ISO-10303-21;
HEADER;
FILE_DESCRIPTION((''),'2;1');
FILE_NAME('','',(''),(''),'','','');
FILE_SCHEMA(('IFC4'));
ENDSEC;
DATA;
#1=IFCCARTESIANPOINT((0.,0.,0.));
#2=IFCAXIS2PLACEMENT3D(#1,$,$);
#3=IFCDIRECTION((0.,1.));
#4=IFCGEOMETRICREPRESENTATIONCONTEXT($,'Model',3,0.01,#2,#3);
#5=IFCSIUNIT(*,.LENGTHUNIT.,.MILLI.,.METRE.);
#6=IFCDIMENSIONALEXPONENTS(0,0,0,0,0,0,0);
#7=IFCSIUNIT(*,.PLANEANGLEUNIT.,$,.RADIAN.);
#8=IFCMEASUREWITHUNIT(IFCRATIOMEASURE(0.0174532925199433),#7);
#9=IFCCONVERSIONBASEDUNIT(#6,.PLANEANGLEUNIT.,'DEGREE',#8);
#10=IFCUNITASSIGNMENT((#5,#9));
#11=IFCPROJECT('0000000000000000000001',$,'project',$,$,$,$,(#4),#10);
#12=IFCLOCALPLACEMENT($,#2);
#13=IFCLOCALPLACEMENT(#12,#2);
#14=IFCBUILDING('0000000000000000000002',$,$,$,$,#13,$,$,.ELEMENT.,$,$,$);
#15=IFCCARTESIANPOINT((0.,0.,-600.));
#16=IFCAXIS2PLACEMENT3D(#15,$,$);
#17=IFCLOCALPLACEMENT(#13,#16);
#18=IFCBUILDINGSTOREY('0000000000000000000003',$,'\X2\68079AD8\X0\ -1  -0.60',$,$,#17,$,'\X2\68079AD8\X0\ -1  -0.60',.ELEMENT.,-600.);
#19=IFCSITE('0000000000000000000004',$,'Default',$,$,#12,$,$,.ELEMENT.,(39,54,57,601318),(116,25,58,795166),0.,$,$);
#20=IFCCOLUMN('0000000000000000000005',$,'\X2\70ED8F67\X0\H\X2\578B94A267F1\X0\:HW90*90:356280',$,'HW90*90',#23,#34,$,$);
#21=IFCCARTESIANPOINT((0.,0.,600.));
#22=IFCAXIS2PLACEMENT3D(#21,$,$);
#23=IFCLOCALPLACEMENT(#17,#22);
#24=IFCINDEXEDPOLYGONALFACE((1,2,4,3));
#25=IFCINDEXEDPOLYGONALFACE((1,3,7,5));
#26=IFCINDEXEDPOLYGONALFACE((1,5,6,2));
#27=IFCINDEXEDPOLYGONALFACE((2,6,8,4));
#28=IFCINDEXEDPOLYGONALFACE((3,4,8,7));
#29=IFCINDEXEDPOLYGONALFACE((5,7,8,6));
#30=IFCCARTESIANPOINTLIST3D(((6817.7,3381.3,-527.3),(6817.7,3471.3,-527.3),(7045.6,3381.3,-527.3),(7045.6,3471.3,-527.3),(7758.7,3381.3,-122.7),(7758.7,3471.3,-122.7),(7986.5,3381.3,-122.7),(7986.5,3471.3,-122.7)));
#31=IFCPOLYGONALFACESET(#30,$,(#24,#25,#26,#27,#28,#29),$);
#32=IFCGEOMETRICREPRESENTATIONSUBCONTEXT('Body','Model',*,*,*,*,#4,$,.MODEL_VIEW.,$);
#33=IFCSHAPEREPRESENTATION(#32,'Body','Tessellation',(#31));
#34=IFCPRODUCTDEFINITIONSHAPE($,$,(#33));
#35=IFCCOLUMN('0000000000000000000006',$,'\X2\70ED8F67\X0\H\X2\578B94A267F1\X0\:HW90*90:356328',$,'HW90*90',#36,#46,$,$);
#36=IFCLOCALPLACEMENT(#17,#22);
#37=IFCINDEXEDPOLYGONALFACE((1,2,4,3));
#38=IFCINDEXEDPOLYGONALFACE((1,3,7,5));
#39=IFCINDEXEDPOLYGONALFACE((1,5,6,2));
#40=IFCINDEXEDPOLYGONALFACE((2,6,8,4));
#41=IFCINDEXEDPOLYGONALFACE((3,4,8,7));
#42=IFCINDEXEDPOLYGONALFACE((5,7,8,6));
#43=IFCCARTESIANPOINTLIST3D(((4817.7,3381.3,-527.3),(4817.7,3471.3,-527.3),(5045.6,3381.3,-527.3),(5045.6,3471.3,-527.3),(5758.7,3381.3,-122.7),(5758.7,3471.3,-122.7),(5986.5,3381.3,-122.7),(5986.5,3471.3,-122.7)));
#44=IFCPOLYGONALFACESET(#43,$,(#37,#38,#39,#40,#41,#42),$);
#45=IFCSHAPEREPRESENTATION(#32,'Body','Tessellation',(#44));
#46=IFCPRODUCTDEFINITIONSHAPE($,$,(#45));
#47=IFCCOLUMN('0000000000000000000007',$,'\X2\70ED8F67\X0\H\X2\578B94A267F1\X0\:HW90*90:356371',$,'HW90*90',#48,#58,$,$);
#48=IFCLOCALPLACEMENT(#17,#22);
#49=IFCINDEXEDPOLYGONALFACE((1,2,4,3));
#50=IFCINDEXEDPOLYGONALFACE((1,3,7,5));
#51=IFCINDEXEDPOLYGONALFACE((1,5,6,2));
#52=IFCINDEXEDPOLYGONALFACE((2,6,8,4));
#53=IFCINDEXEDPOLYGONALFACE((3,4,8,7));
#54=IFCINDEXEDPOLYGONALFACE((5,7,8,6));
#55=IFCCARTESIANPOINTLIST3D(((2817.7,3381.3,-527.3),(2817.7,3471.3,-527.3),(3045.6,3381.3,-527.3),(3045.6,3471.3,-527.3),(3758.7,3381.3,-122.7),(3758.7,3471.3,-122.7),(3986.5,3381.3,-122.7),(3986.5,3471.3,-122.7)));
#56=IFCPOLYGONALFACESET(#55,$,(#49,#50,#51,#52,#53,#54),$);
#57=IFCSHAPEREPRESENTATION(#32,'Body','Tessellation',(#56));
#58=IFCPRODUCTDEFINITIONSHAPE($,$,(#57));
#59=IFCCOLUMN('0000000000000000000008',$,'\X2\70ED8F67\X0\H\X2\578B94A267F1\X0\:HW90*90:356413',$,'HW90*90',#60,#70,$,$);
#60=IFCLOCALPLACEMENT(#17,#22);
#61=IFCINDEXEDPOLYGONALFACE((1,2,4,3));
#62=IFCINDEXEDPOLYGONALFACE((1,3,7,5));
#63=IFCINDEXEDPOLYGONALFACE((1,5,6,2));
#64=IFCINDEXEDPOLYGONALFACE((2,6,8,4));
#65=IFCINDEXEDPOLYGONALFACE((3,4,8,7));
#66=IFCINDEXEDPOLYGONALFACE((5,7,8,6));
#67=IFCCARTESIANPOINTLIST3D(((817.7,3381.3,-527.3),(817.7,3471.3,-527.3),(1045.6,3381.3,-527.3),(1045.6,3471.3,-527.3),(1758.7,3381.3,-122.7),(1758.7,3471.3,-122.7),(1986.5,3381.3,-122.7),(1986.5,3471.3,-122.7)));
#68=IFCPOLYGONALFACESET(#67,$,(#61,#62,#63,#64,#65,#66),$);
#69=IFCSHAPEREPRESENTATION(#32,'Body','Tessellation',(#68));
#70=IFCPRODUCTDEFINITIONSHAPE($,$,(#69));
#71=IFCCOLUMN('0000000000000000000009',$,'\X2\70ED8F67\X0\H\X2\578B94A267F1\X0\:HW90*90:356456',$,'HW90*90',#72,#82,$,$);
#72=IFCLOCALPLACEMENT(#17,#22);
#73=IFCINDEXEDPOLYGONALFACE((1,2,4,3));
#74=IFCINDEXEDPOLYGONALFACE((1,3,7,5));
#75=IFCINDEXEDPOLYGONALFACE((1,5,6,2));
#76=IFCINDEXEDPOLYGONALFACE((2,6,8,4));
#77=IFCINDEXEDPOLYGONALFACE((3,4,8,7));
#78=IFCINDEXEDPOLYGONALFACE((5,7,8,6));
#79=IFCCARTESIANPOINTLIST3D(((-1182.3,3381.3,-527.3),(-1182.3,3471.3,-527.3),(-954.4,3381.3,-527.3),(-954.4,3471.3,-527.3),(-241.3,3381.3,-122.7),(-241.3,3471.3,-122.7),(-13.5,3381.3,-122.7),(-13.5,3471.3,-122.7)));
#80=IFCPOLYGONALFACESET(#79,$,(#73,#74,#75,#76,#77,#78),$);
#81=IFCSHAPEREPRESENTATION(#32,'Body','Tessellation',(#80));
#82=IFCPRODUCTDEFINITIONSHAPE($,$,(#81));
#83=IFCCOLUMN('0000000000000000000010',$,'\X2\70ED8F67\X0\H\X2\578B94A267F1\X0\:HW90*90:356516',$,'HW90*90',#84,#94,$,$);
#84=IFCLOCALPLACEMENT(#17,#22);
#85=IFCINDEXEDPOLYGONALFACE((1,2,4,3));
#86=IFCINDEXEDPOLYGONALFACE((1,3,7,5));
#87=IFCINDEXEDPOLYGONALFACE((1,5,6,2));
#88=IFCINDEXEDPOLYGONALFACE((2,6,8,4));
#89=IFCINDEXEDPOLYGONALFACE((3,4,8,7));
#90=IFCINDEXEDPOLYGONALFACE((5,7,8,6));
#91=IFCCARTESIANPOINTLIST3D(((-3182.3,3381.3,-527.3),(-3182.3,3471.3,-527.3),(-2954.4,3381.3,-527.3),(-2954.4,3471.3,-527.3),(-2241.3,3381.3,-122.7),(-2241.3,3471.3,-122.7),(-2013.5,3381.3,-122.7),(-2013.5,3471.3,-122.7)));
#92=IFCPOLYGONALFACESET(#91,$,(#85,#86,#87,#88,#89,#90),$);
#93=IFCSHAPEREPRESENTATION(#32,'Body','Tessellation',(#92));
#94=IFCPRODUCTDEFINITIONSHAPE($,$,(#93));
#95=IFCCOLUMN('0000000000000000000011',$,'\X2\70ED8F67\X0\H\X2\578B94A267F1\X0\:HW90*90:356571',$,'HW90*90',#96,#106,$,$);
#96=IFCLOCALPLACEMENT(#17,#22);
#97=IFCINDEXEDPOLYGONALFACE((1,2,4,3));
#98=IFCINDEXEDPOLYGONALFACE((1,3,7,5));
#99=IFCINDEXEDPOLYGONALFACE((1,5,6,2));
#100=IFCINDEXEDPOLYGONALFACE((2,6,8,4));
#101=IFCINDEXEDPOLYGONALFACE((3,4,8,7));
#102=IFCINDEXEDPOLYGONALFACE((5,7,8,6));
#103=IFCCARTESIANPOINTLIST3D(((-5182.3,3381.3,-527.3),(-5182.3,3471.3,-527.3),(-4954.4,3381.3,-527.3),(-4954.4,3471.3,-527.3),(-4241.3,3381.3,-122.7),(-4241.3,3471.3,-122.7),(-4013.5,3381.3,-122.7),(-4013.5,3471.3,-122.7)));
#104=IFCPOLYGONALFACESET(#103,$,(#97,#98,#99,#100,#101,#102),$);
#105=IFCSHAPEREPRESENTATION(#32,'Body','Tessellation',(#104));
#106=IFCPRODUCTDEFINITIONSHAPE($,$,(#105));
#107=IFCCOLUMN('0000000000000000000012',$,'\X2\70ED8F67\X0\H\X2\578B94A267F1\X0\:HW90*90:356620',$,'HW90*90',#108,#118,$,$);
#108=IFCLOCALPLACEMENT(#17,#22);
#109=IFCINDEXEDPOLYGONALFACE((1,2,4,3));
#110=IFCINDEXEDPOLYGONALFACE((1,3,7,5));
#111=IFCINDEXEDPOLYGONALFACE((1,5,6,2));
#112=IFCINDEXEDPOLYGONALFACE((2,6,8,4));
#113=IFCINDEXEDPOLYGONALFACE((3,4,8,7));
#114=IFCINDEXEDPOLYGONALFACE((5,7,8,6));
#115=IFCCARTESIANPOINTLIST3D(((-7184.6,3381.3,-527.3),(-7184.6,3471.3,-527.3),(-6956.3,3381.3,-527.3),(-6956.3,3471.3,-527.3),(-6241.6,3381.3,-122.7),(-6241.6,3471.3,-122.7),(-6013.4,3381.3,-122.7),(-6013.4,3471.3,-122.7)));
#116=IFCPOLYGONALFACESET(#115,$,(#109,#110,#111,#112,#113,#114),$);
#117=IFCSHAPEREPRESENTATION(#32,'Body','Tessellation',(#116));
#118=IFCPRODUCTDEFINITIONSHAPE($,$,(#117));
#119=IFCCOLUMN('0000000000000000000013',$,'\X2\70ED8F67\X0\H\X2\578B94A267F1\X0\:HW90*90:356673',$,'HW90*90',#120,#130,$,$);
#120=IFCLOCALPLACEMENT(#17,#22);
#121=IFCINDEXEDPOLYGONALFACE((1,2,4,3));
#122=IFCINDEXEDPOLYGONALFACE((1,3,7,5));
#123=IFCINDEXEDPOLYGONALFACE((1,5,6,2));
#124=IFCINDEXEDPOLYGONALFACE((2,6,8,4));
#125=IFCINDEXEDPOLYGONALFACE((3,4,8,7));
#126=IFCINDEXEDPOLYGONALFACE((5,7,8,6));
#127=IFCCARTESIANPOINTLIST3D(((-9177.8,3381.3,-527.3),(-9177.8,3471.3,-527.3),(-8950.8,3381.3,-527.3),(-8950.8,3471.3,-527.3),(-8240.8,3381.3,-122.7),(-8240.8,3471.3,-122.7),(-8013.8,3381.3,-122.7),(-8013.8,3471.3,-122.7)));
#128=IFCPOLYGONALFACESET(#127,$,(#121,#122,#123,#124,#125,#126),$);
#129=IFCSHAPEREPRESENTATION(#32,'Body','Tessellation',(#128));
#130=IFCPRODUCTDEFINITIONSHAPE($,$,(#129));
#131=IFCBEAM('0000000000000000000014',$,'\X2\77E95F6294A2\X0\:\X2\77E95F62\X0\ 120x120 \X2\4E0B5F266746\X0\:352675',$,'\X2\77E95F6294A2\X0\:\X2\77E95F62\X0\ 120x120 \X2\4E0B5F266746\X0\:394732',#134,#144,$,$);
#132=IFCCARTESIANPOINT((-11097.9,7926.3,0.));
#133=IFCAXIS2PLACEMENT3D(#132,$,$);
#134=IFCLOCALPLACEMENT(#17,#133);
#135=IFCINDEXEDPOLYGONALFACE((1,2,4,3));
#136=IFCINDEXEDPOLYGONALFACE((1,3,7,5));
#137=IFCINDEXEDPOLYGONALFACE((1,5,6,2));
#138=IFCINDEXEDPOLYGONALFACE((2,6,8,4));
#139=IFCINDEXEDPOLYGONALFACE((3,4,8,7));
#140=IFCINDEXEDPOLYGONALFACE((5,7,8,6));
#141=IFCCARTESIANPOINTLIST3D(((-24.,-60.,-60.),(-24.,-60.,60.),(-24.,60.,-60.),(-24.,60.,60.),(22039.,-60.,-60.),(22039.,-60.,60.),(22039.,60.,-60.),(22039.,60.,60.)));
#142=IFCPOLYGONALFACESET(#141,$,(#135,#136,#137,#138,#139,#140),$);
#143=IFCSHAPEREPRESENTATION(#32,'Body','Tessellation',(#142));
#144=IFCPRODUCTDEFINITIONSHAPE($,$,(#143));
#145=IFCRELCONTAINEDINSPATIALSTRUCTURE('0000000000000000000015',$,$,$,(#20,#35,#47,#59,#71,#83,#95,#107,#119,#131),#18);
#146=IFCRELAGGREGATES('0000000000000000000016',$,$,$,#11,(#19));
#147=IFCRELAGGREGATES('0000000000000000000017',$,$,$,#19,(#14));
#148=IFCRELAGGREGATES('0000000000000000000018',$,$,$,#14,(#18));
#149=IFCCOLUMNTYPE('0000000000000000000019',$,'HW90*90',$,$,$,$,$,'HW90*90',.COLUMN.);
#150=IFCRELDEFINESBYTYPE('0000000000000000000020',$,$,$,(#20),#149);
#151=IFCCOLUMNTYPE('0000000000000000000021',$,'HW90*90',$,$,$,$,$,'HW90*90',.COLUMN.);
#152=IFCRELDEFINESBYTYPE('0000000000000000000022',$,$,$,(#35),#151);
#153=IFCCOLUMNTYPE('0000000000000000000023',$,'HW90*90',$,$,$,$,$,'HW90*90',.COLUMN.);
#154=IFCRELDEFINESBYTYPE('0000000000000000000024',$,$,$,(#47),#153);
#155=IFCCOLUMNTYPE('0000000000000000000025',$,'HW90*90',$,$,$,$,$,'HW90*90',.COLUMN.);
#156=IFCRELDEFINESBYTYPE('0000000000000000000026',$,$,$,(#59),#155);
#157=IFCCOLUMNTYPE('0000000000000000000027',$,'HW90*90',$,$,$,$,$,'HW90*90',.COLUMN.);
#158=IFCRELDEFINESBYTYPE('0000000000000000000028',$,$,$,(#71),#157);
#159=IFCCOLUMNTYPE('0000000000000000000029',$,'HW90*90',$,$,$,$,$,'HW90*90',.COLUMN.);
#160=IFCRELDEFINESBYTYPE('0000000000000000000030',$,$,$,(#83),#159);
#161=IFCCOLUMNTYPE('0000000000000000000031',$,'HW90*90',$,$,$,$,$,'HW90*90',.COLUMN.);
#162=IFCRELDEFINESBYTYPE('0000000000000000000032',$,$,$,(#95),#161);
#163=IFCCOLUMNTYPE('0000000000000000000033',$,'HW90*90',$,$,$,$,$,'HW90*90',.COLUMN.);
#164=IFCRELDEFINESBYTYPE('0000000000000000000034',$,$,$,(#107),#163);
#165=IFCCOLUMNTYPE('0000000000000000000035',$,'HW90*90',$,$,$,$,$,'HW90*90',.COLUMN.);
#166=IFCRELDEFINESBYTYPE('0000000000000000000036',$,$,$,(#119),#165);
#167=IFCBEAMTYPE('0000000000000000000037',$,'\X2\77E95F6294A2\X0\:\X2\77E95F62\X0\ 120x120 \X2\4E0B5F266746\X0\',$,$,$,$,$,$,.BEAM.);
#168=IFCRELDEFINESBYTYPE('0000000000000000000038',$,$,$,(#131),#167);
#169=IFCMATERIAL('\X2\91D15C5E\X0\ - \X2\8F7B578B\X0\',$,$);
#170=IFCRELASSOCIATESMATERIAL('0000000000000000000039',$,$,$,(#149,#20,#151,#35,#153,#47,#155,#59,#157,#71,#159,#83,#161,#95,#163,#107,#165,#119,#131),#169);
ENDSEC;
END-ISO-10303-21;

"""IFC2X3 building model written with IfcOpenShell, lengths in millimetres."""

from ifc_helpers import new_model, entity, si_unit, converted_unit, direction, frame, frame_2d, origin, place, context, subcontext, project, spatial, rectangle, extrude, clip, halfspace, source, transform, mapped, material, type_object, type_shapes, element, save


model = new_model("IFC2X3")

# Units and contexts
model_context = context("Model", 3, precision=0.01, world=origin(), true_north=direction((0.0, 1.0)))
body_context = subcontext(model_context, "Body", "Model", "MODEL_VIEW")
ifc_project = project(units=[si_unit("LENGTHUNIT", "METRE", prefix="MILLI"), converted_unit("PLANEANGLEUNIT", "DEGREE", entity("IfcRatioMeasure", 0.0174532925199433), si_unit("PLANEANGLEUNIT", "RADIAN"), dimensions=[0, 0, 0, 0, 0, 0, 0])], contexts=[model_context])

# Site, building, storey
site_placement = place(None, origin())
site = spatial("IfcSite", under=ifc_project, at=site_placement, Name="Default", CompositionType="ELEMENT", RefLatitude=(39, 54, 57, 601318), RefLongitude=(116, 25, 58, 795166), RefElevation=0.0)
building_placement = place(site_placement, origin())
building = spatial("IfcBuilding", under=site, at=building_placement, CompositionType="ELEMENT")
storey_placement = place(building_placement, frame((0.0, 0.0, -600.0)))
storey = spatial("IfcBuildingStorey", under=building, at=storey_placement, Name="标高 -1  -0.60", LongName="标高 -1  -0.60", CompositionType="ELEMENT", Elevation=-600.0)

# Columns
ifc_material = material(Name="金属 - 轻型")
column_type_1 = type_object("IfcColumnType", Name="HW90*90", ElementType="HW90*90", PredefinedType="COLUMN", material=ifc_material)
shared_shape_1 = source(origin(), body_context, "Body", "Clipping", [
    clip(clip(extrude(rectangle(XDim=90.0, YDim=1168.8, at=frame_2d((0.0, 0.0), x_axis=(1.0, 0.0))), frame((7402.1, 3426.3, -527.3), z_axis=(0.0, 0.0, 1.0), x_axis=(0.0, -1.0, 0.0)), (0.0, 0.0, 1.0), 404.6), halfspace(frame((8186.4, 3381.3, -36.8), z_axis=(0.395028, 0.0, -0.918669), x_axis=(-0.918669, 0.0, -0.395028)), False)), halfspace(frame((8150.8, 3471.3, 45.9), z_axis=(-0.395028, 0.0, 0.918669), x_axis=(-0.918669, 0.0, -0.395028)), False)),
])
type_shapes(column_type_1, [shared_shape_1])
column_1_placement = place(storey_placement, frame((0.0, 0.0, 600.0)))
element("IfcColumn", 1, at=column_1_placement, inside=storey, type_object=column_type_1, material=ifc_material, Name="热轧H型钢柱:HW90*90:356280", ObjectType="HW90*90", context=body_context, shape_type="MappedRepresentation", body=[
    mapped(shared_shape_1, transform((0.0, 0.0, 0.0), scale=1.0)),
])
column_type_2 = type_object("IfcColumnType", Name="HW90*90", ElementType="HW90*90", PredefinedType="COLUMN", material=ifc_material)
shared_shape_2 = source(origin(), body_context, "Body", "Clipping", [
    clip(clip(extrude(rectangle(XDim=90.0, YDim=1168.8, at=frame_2d((0.0, 0.0), x_axis=(1.0, 0.0))), frame((5402.1, 3426.3, -527.3), z_axis=(0.0, 0.0, 1.0), x_axis=(0.0, -1.0, 0.0)), (0.0, 0.0, 1.0), 404.6), halfspace(frame((6186.4, 3381.3, -36.8), z_axis=(0.395028, 0.0, -0.918669), x_axis=(-0.918669, 0.0, -0.395028)), False)), halfspace(frame((6150.8, 3471.3, 45.9), z_axis=(-0.395028, 0.0, 0.918669), x_axis=(-0.918669, 0.0, -0.395028)), False)),
])
type_shapes(column_type_2, [shared_shape_2])
column_2_placement = place(storey_placement, frame((0.0, 0.0, 600.0)))
element("IfcColumn", 2, at=column_2_placement, inside=storey, type_object=column_type_2, material=ifc_material, Name="热轧H型钢柱:HW90*90:356328", ObjectType="HW90*90", context=body_context, shape_type="MappedRepresentation", body=[
    mapped(shared_shape_2, transform((0.0, 0.0, 0.0), scale=1.0)),
])
column_type_3 = type_object("IfcColumnType", Name="HW90*90", ElementType="HW90*90", PredefinedType="COLUMN", material=ifc_material)
shared_shape_3 = source(origin(), body_context, "Body", "Clipping", [
    clip(clip(extrude(rectangle(XDim=90.0, YDim=1168.8, at=frame_2d((0.0, 0.0), x_axis=(1.0, 0.0))), frame((3402.1, 3426.3, -527.3), z_axis=(0.0, 0.0, 1.0), x_axis=(0.0, -1.0, 0.0)), (0.0, 0.0, 1.0), 404.6), halfspace(frame((4186.4, 3381.3, -36.8), z_axis=(0.395028, 0.0, -0.918669), x_axis=(-0.918669, 0.0, -0.395028)), False)), halfspace(frame((4150.8, 3471.3, 45.9), z_axis=(-0.395028, 0.0, 0.918669), x_axis=(-0.918669, 0.0, -0.395028)), False)),
])
type_shapes(column_type_3, [shared_shape_3])
column_3_placement = place(storey_placement, frame((0.0, 0.0, 600.0)))
element("IfcColumn", 3, at=column_3_placement, inside=storey, type_object=column_type_3, material=ifc_material, Name="热轧H型钢柱:HW90*90:356371", ObjectType="HW90*90", context=body_context, shape_type="MappedRepresentation", body=[
    mapped(shared_shape_3, transform((0.0, 0.0, 0.0), scale=1.0)),
])
column_type_4 = type_object("IfcColumnType", Name="HW90*90", ElementType="HW90*90", PredefinedType="COLUMN", material=ifc_material)
shared_shape_4 = source(origin(), body_context, "Body", "Clipping", [
    clip(clip(extrude(rectangle(XDim=90.0, YDim=1168.8, at=frame_2d((0.0, 0.0), x_axis=(1.0, 0.0))), frame((1402.1, 3426.3, -527.3), z_axis=(0.0, 0.0, 1.0), x_axis=(0.0, -1.0, 0.0)), (0.0, 0.0, 1.0), 404.6), halfspace(frame((2150.8, 3471.3, 45.9), z_axis=(-0.395028, 0.0, 0.918669), x_axis=(-0.918669, 0.0, -0.395028)), False)), halfspace(frame((2186.4, 3381.3, -36.8), z_axis=(0.395028, 0.0, -0.918669), x_axis=(-0.918669, 0.0, -0.395028)), False)),
])
type_shapes(column_type_4, [shared_shape_4])
column_4_placement = place(storey_placement, frame((0.0, 0.0, 600.0)))
element("IfcColumn", 4, at=column_4_placement, inside=storey, type_object=column_type_4, material=ifc_material, Name="热轧H型钢柱:HW90*90:356413", ObjectType="HW90*90", context=body_context, shape_type="MappedRepresentation", body=[
    mapped(shared_shape_4, transform((0.0, 0.0, 0.0), scale=1.0)),
])
column_type_5 = type_object("IfcColumnType", Name="HW90*90", ElementType="HW90*90", PredefinedType="COLUMN", material=ifc_material)
shared_shape_5 = source(origin(), body_context, "Body", "Clipping", [
    clip(clip(extrude(rectangle(XDim=90.0, YDim=1168.8, at=frame_2d((0.0, 0.0), x_axis=(1.0, 0.0))), frame((-597.9, 3426.3, -527.3), z_axis=(0.0, 0.0, 1.0), x_axis=(0.0, -1.0, 0.0)), (0.0, 0.0, 1.0), 404.6), halfspace(frame((186.4, 3381.3, -36.8), z_axis=(0.395028, 0.0, -0.918669), x_axis=(-0.918669, 0.0, -0.395028)), False)), halfspace(frame((150.8, 3471.3, 45.9), z_axis=(-0.395028, 0.0, 0.918669), x_axis=(-0.918669, 0.0, -0.395028)), False)),
])
type_shapes(column_type_5, [shared_shape_5])
column_5_placement = place(storey_placement, frame((0.0, 0.0, 600.0)))
element("IfcColumn", 5, at=column_5_placement, inside=storey, type_object=column_type_5, material=ifc_material, Name="热轧H型钢柱:HW90*90:356456", ObjectType="HW90*90", context=body_context, shape_type="MappedRepresentation", body=[
    mapped(shared_shape_5, transform((0.0, 0.0, 0.0), scale=1.0)),
])
column_type_6 = type_object("IfcColumnType", Name="HW90*90", ElementType="HW90*90", PredefinedType="COLUMN", material=ifc_material)
shared_shape_6 = source(origin(), body_context, "Body", "Clipping", [
    clip(clip(extrude(rectangle(XDim=90.0, YDim=1168.8, at=frame_2d((0.0, 0.0), x_axis=(1.0, 0.0))), frame((-2597.9, 3426.3, -527.3), z_axis=(0.0, 0.0, 1.0), x_axis=(0.0, -1.0, 0.0)), (0.0, 0.0, 1.0), 404.6), halfspace(frame((-1849.2, 3471.3, 45.9), z_axis=(-0.395028, 0.0, 0.918669), x_axis=(-0.918669, 0.0, -0.395028)), False)), halfspace(frame((-1813.6, 3381.3, -36.8), z_axis=(0.395028, 0.0, -0.918669), x_axis=(-0.918669, 0.0, -0.395028)), False)),
])
type_shapes(column_type_6, [shared_shape_6])
column_6_placement = place(storey_placement, frame((0.0, 0.0, 600.0)))
element("IfcColumn", 6, at=column_6_placement, inside=storey, type_object=column_type_6, material=ifc_material, Name="热轧H型钢柱:HW90*90:356516", ObjectType="HW90*90", context=body_context, shape_type="MappedRepresentation", body=[
    mapped(shared_shape_6, transform((0.0, 0.0, 0.0), scale=1.0)),
])
column_type_7 = type_object("IfcColumnType", Name="HW90*90", ElementType="HW90*90", PredefinedType="COLUMN", material=ifc_material)
shared_shape_7 = source(origin(), body_context, "Body", "Clipping", [
    clip(clip(extrude(rectangle(XDim=90.0, YDim=1168.8, at=frame_2d((0.0, 0.0), x_axis=(1.0, 0.0))), frame((-4597.9, 3426.3, -527.3), z_axis=(0.0, 0.0, 1.0), x_axis=(0.0, -1.0, 0.0)), (0.0, 0.0, 1.0), 404.6), halfspace(frame((-3849.2, 3471.3, 45.9), z_axis=(-0.395028, 0.0, 0.918669), x_axis=(-0.918669, 0.0, -0.395028)), False)), halfspace(frame((-3813.6, 3381.3, -36.8), z_axis=(0.395028, 0.0, -0.918669), x_axis=(-0.918669, 0.0, -0.395028)), False)),
])
type_shapes(column_type_7, [shared_shape_7])
column_7_placement = place(storey_placement, frame((0.0, 0.0, 600.0)))
element("IfcColumn", 7, at=column_7_placement, inside=storey, type_object=column_type_7, material=ifc_material, Name="热轧H型钢柱:HW90*90:356571", ObjectType="HW90*90", context=body_context, shape_type="MappedRepresentation", body=[
    mapped(shared_shape_7, transform((0.0, 0.0, 0.0), scale=1.0)),
])
column_type_8 = type_object("IfcColumnType", Name="HW90*90", ElementType="HW90*90", PredefinedType="COLUMN", material=ifc_material)
shared_shape_8 = source(origin(), body_context, "Body", "Clipping", [
    clip(clip(extrude(rectangle(XDim=90.0, YDim=1171.2, at=frame_2d((0.0, 0.0), x_axis=(1.0, 0.0))), frame((-6599.0, 3426.3, -527.3), z_axis=(0.0, 0.0, 1.0), x_axis=(0.0, -1.0, 0.0)), (0.0, 0.0, 1.0), 404.6), halfspace(frame((-5848.6, 3471.3, 45.9), z_axis=(-0.394305, 0.0, 0.91898), x_axis=(-0.91898, 0.0, -0.394305)), False)), halfspace(frame((-5813.1, 3381.3, -36.8), z_axis=(0.394305, 0.0, -0.91898), x_axis=(-0.91898, 0.0, -0.394305)), False)),
])
type_shapes(column_type_8, [shared_shape_8])
column_8_placement = place(storey_placement, frame((0.0, 0.0, 600.0)))
element("IfcColumn", 8, at=column_8_placement, inside=storey, type_object=column_type_8, material=ifc_material, Name="热轧H型钢柱:HW90*90:356620", ObjectType="HW90*90", context=body_context, shape_type="MappedRepresentation", body=[
    mapped(shared_shape_8, transform((0.0, 0.0, 0.0), scale=1.0)),
])
column_type_9 = type_object("IfcColumnType", Name="HW90*90", ElementType="HW90*90", PredefinedType="COLUMN", material=ifc_material)
shared_shape_9 = source(origin(), body_context, "Body", "Clipping", [
    clip(clip(extrude(rectangle(XDim=90.0, YDim=1164.1, at=frame_2d((0.0, 0.0), x_axis=(1.0, 0.0))), frame((-8595.8, 3426.3, -527.3), z_axis=(0.0, 0.0, 1.0), x_axis=(0.0, -1.0, 0.0)), (0.0, 0.0, 1.0), 404.6), halfspace(frame((-7850.4, 3471.3, 45.9), z_axis=(-0.396412, 0.0, 0.918073), x_axis=(-0.918073, 0.0, -0.396412)), False)), halfspace(frame((-7814.7, 3381.3, -36.7), z_axis=(0.396412, 0.0, -0.918073), x_axis=(-0.918073, 0.0, -0.396412)), False)),
])
type_shapes(column_type_9, [shared_shape_9])
column_9_placement = place(storey_placement, frame((0.0, 0.0, 600.0)))
element("IfcColumn", 9, at=column_9_placement, inside=storey, type_object=column_type_9, material=ifc_material, Name="热轧H型钢柱:HW90*90:356673", ObjectType="HW90*90", context=body_context, shape_type="MappedRepresentation", body=[
    mapped(shared_shape_9, transform((0.0, 0.0, 0.0), scale=1.0)),
])

# Beam
beam_type = type_object("IfcBeamType", Name="矩形钢:矩形 120x120 下弦杆", PredefinedType="BEAM")
beam_placement = place(storey_placement, frame((-11097.9, 7926.3, 0.0)))
element("IfcBeam", 10, at=beam_placement, inside=storey, type_object=beam_type, material=ifc_material, Name="矩形钢:矩形 120x120 下弦杆:352675", ObjectType="矩形钢:矩形 120x120 下弦杆:394732", context=body_context, shape_type="SweptSolid", body=[
    extrude(rectangle(XDim=120.0, YDim=120.0, at=frame_2d((0.0, 0.0), x_axis=(1.0, 0.0))), frame((-24.0, 0.0, 0.0), z_axis=(1.0, 0.0, 0.0), x_axis=(0.0, 0.0, -1.0)), (0.0, 0.0, 1.0), 22063.0),
])

save(model, "model.ifc")
